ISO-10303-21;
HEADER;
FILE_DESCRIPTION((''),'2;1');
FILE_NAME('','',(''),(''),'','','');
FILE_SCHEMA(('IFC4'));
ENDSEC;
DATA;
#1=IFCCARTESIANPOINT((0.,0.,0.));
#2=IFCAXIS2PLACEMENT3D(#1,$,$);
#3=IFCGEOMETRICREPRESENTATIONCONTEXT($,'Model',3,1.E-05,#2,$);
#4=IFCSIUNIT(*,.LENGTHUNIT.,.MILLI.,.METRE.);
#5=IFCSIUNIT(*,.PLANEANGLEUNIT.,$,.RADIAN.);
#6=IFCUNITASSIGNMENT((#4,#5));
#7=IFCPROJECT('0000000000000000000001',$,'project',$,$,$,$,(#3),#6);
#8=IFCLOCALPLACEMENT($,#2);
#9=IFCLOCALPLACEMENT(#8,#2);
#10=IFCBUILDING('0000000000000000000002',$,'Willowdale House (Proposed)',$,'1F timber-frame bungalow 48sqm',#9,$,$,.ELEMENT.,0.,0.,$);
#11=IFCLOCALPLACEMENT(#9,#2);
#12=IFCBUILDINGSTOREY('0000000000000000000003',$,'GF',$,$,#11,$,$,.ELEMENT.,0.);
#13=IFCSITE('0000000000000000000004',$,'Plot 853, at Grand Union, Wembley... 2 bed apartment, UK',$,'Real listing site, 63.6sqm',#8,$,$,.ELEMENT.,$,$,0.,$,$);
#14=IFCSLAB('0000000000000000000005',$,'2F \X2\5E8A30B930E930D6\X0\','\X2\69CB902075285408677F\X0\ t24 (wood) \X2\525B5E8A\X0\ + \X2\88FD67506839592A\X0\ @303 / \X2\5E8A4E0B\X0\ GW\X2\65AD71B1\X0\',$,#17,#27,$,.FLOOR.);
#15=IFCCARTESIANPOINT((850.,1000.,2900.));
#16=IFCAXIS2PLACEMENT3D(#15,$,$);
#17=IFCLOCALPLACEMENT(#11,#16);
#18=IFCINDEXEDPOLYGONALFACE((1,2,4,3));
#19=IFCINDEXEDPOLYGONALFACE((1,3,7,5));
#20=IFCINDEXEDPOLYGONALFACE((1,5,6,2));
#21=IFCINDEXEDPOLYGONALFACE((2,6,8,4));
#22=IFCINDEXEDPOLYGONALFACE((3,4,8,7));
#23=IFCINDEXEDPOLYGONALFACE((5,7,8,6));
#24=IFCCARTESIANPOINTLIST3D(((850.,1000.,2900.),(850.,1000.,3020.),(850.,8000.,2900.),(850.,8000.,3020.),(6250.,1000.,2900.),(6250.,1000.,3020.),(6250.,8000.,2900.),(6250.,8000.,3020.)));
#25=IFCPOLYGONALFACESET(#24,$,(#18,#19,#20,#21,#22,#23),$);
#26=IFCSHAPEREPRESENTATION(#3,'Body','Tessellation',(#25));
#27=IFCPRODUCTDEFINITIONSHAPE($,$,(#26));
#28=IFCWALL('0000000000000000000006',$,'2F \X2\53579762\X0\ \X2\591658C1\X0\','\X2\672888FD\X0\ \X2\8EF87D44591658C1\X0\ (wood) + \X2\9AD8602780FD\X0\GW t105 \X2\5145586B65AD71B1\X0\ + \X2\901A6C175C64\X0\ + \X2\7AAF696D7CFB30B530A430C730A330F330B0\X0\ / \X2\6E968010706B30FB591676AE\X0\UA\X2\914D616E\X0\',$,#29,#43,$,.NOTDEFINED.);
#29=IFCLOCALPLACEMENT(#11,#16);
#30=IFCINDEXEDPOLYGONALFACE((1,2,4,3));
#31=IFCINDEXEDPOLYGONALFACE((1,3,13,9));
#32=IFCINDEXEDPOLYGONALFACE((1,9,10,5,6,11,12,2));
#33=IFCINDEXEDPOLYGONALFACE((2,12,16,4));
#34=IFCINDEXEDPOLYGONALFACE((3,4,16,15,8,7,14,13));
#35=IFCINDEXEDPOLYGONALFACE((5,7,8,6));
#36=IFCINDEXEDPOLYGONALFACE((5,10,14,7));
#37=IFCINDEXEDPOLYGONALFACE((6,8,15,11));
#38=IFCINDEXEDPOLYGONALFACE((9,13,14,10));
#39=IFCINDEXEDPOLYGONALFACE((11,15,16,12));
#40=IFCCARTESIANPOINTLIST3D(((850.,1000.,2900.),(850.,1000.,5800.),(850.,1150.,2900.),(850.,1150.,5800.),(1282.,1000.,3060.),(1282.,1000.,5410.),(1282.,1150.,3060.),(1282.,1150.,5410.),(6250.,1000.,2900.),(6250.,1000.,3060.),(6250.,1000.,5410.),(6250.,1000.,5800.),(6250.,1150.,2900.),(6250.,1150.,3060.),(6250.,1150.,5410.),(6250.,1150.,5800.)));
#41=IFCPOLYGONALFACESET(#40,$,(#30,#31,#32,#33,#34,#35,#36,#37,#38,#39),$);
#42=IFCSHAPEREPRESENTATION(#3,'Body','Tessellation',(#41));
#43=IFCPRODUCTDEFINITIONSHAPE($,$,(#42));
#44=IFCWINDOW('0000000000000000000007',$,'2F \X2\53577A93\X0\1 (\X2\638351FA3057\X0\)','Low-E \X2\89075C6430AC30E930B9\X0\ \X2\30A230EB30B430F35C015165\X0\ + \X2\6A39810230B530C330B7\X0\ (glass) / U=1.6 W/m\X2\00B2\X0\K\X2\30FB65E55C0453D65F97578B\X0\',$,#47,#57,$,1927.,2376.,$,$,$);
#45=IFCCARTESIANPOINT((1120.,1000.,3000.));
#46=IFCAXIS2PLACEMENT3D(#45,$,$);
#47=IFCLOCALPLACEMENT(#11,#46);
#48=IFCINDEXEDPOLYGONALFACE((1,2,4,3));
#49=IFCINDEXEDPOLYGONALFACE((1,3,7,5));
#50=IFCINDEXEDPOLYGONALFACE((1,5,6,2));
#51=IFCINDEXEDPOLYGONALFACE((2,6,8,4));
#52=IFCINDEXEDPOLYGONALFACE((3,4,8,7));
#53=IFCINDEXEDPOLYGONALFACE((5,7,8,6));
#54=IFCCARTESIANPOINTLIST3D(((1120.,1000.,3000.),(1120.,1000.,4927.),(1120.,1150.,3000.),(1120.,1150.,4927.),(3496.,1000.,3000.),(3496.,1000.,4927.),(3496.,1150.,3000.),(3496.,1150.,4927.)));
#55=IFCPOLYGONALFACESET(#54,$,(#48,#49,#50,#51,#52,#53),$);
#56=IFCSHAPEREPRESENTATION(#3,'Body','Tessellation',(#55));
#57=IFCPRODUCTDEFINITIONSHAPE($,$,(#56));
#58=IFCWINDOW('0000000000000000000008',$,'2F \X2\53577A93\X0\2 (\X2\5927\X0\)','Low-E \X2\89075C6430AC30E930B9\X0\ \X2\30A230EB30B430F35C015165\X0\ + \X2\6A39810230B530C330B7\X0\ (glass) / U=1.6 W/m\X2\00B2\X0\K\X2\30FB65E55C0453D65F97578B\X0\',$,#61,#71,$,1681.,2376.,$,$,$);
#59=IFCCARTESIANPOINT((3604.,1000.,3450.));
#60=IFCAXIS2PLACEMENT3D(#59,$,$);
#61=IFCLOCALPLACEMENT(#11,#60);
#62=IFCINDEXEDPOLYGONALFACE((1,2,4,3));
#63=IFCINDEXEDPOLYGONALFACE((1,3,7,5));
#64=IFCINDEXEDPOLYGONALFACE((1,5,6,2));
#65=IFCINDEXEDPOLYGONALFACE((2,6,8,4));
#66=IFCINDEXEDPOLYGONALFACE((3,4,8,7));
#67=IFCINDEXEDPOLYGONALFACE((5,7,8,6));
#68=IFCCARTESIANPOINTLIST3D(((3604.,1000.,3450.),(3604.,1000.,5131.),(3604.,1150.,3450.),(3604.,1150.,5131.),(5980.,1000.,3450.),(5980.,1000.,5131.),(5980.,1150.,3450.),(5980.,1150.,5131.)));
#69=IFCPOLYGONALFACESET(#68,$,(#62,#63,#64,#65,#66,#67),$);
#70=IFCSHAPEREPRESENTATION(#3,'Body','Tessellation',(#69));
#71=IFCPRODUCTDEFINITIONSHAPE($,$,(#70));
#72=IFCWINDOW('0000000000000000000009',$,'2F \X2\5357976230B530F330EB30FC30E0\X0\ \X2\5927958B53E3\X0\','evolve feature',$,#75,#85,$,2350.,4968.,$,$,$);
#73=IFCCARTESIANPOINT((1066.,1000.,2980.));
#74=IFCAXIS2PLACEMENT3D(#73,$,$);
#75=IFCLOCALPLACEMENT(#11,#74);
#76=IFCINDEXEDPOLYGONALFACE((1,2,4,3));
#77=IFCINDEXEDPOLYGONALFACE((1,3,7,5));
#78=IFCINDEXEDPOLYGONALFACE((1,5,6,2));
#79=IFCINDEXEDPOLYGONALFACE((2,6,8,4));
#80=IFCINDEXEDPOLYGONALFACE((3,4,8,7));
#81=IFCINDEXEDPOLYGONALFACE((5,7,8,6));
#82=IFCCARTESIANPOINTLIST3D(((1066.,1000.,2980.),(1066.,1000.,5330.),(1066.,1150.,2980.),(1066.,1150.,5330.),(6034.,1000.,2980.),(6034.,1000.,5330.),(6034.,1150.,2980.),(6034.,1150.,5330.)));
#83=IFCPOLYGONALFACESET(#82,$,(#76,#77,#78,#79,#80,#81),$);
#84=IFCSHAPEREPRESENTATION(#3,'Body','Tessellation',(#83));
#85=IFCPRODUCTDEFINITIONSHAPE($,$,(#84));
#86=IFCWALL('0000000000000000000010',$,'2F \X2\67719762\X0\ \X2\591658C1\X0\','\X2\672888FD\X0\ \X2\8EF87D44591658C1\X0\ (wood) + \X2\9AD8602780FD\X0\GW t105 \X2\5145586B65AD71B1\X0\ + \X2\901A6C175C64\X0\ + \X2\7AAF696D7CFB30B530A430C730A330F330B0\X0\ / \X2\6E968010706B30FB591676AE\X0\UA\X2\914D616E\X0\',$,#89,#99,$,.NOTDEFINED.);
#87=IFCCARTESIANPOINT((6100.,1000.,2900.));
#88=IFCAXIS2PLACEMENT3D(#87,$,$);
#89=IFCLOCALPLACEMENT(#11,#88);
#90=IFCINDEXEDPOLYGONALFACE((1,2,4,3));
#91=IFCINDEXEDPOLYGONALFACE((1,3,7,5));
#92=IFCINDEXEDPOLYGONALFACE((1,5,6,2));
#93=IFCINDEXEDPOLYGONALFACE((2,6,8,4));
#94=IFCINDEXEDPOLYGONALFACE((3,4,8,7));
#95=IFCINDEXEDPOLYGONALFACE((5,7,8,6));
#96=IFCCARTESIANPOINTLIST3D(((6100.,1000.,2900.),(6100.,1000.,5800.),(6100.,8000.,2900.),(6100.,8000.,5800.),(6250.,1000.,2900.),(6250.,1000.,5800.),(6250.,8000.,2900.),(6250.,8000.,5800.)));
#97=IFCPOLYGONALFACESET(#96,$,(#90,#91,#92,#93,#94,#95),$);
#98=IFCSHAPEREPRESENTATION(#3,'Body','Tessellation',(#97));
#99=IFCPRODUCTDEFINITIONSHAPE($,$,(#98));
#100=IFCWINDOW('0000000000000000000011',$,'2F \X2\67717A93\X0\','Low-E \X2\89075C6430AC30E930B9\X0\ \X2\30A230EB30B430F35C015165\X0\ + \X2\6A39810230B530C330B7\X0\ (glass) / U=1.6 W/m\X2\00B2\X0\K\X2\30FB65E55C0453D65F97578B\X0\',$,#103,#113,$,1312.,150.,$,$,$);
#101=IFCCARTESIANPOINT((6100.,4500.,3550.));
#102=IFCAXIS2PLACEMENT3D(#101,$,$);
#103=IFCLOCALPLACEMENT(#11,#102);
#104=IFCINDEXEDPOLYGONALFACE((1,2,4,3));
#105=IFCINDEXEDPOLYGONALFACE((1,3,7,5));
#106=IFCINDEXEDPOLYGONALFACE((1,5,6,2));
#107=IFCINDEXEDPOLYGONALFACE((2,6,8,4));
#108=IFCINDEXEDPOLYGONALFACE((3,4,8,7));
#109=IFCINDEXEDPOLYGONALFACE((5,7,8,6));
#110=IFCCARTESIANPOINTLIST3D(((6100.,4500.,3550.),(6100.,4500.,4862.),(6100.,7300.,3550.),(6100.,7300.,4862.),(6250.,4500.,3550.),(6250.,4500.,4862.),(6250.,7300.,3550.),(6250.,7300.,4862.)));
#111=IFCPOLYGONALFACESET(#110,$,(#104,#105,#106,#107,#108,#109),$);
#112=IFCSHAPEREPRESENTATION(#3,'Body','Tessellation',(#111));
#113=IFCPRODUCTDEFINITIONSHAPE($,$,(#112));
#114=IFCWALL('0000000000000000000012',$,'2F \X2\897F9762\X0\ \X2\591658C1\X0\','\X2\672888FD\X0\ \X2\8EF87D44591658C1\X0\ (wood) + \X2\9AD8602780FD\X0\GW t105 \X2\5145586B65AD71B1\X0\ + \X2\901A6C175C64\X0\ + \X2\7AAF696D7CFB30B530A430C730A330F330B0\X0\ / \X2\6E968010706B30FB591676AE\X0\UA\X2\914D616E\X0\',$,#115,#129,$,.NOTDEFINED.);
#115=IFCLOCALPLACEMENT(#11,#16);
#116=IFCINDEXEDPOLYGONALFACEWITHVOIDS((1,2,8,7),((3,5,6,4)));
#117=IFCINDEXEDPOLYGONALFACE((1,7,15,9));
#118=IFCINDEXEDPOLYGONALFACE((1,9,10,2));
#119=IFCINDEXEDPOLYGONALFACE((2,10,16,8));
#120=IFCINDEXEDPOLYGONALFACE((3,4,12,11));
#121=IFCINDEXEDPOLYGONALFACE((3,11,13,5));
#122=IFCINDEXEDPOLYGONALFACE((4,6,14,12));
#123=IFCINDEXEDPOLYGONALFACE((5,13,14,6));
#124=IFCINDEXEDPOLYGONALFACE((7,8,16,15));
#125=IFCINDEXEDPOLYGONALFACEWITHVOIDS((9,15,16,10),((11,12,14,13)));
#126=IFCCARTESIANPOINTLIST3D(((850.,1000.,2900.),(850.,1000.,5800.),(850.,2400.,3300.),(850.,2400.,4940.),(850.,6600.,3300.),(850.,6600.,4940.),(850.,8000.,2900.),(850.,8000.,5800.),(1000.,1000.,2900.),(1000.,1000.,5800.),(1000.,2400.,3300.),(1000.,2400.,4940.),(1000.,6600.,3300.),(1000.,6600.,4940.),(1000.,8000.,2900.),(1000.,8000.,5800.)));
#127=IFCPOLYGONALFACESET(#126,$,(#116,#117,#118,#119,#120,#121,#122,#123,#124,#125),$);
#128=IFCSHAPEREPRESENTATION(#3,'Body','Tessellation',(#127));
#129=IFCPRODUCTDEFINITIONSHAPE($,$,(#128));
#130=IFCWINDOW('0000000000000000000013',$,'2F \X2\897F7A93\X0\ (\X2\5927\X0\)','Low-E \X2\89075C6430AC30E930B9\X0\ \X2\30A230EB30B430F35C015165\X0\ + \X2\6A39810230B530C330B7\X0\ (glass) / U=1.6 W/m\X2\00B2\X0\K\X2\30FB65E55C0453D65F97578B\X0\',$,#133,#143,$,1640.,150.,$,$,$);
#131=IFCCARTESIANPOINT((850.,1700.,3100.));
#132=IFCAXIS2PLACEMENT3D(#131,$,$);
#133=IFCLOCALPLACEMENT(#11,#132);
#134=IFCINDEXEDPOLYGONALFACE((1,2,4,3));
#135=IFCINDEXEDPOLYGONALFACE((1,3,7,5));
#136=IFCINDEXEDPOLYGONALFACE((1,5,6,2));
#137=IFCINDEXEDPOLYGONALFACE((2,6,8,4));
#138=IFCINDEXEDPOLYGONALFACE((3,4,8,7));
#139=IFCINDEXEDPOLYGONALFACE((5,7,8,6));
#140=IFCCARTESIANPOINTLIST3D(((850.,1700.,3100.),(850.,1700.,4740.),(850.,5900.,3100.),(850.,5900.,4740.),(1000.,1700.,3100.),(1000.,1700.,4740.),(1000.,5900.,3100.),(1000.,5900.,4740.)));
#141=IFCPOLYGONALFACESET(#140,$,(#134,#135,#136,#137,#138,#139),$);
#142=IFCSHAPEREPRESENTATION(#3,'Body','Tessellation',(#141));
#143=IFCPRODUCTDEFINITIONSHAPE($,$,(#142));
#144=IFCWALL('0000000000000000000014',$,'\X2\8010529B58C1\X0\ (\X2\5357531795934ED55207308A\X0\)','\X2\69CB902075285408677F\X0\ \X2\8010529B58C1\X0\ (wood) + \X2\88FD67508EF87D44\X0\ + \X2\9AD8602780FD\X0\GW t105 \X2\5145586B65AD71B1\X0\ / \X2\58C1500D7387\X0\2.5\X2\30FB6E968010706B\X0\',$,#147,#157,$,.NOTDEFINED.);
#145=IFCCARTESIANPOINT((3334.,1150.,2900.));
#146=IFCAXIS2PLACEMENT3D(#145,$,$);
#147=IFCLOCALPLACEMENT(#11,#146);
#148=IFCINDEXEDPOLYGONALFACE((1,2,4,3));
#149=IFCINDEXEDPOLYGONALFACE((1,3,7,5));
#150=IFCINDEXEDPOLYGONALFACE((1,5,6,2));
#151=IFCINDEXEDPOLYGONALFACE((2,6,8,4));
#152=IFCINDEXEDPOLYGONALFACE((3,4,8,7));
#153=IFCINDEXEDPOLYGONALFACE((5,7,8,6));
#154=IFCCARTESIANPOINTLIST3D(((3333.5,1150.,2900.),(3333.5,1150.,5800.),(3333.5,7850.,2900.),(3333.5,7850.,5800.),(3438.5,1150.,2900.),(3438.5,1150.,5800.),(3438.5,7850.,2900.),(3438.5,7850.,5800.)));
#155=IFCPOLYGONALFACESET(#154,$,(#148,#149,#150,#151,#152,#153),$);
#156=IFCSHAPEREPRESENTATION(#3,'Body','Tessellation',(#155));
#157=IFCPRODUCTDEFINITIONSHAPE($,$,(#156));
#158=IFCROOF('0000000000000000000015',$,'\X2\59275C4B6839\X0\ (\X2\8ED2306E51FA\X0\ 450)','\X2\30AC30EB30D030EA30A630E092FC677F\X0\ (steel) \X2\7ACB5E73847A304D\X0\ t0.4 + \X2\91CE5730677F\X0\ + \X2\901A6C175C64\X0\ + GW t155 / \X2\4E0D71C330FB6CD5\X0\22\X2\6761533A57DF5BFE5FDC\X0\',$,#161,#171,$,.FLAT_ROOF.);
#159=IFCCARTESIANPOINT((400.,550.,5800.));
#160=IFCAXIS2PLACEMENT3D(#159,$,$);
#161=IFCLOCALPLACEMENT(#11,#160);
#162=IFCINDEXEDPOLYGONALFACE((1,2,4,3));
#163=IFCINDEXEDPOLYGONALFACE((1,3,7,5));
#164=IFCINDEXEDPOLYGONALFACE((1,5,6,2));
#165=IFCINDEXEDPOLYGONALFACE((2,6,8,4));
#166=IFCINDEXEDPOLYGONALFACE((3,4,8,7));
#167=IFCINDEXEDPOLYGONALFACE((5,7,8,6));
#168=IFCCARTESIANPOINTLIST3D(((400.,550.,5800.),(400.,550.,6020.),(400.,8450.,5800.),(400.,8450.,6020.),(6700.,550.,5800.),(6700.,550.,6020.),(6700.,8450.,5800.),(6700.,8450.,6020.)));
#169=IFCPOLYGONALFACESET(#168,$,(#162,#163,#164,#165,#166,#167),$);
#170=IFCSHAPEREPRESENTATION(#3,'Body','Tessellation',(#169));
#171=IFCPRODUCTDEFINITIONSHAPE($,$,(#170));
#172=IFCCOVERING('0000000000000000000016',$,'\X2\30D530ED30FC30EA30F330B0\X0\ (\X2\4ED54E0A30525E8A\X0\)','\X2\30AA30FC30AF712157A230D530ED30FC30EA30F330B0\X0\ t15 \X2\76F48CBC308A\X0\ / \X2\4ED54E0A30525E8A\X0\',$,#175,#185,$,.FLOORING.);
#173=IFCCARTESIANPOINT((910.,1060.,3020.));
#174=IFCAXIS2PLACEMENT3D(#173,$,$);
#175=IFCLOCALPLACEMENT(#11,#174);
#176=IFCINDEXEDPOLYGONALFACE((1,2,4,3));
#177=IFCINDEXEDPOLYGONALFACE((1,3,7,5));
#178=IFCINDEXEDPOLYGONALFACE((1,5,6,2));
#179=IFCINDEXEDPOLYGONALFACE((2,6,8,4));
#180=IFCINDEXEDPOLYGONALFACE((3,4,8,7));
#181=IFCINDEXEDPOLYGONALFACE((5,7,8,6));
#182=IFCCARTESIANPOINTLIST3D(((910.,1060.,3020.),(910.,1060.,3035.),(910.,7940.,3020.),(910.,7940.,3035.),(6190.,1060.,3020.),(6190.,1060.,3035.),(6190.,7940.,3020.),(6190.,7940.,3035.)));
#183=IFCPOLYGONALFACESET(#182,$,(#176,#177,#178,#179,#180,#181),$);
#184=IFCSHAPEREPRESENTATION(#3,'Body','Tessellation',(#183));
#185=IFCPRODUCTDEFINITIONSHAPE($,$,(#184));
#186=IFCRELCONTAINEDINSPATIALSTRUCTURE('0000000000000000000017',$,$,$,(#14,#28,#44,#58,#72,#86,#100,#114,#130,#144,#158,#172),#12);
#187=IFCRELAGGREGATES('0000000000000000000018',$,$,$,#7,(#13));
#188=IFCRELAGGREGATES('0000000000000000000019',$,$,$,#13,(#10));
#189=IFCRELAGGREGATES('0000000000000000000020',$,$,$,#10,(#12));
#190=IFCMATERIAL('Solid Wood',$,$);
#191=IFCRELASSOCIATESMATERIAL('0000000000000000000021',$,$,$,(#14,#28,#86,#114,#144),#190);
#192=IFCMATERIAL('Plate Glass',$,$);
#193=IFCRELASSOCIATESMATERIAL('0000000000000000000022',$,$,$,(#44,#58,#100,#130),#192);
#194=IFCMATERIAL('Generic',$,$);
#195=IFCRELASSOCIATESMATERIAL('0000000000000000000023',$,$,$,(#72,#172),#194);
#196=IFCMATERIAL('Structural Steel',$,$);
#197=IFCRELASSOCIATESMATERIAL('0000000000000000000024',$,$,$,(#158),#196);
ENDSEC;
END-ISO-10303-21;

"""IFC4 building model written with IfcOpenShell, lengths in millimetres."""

from ifc_helpers import new_model, si_unit, frame, frame_2d, origin, place, context, project, spatial, rectangle, extrude, material, element, fill, save


model = new_model("IFC4")

# Units and contexts
model_context = context("Model", 3, precision=1e-05, world=origin())
ifc_project = project(units=[si_unit("LENGTHUNIT", "METRE", prefix="MILLI"), si_unit("PLANEANGLEUNIT", "RADIAN")], contexts=[model_context])

# Site, building, storey
site_placement = place(None, origin())
site = spatial("IfcSite", under=ifc_project, at=site_placement, Name="Plot 853, at Grand Union, Wembley... 2 bed apartment, UK", ObjectType="Real listing site, 63.6sqm", CompositionType="ELEMENT", RefElevation=0.0)
building_placement = place(site_placement, origin())
building = spatial("IfcBuilding", under=site, at=building_placement, Name="Willowdale House (Proposed)", ObjectType="1F timber-frame bungalow 48sqm", CompositionType="ELEMENT", ElevationOfRefHeight=0.0, ElevationOfTerrain=0.0)
storey_placement = place(building_placement, origin())
storey = spatial("IfcBuildingStorey", under=building, at=storey_placement, Name="GF", CompositionType="ELEMENT", Elevation=0.0)

# Slab
ifc_material_1 = material(Name="Solid Wood")
slab_placement = place(storey_placement, frame((850.0, 1000.0, 2900.0)))
element("IfcSlab", 1, at=slab_placement, inside=storey, material=ifc_material_1, Name="2F 床スラブ", Description="構造用合板 t24 (wood) 剛床 + 製材根太 @303 / 床下 GW断熱", PredefinedType="FLOOR", context=model_context, shape_type="SweptSolid", body=[
    extrude(rectangle(XDim=5400.0, YDim=7000.0, at=frame_2d((2700.0, 3500.0))), frame((850.0, 1000.0, 2900.0)), (0.0, 0.0, 1.0), 120.0),
])

# Wall, openings, windows
wall_1_placement = place(storey_placement, frame((850.0, 1000.0, 2900.0)))
wall_1 = element("IfcWall", 2, at=wall_1_placement, inside=storey, material=ifc_material_1, Name="2F 南面 外壁", Description="木製 軸組外壁 (wood) + 高性能GW t105 充填断熱 + 通気層 + 窯業系サイディング / 準耐火・外皮UA配慮", PredefinedType="NOTDEFINED", context=model_context, shape_type="SweptSolid", body=[
    extrude(rectangle(XDim=5400.0, YDim=150.0, at=frame_2d((2700.0, 75.0))), frame((850.0, 1000.0, 2900.0)), (0.0, 0.0, 1.0), 2900.0),
])
opening_1_placement = place(storey_placement, frame((1120.0, 1000.0, 3000.0)))
opening_1 = element("IfcOpeningElement", 3, at=opening_1_placement, cuts=wall_1, PredefinedType="NOTDEFINED", context=model_context, shape_type="SweptSolid", body=[
    extrude(rectangle(XDim=2376.0, YDim=150.0, at=frame_2d((1188.0, 75.0))), frame((1120.0, 1000.0, 3000.0)), (0.0, 0.0, 1.0), 1927.0),
])
opening_2_placement = place(storey_placement, frame((3604.0, 1000.0, 3450.0)))
opening_2 = element("IfcOpeningElement", 4, at=opening_2_placement, cuts=wall_1, PredefinedType="NOTDEFINED", context=model_context, shape_type="SweptSolid", body=[
    extrude(rectangle(XDim=2376.0, YDim=150.0, at=frame_2d((1188.0, 75.0))), frame((3604.0, 1000.0, 3450.0)), (0.0, 0.0, 1.0), 1681.0),
])
opening_3_placement = place(storey_placement, frame((1066.0, 1000.0, 2980.0)))
opening_3 = element("IfcOpeningElement", 5, at=opening_3_placement, cuts=wall_1, PredefinedType="NOTDEFINED", context=model_context, shape_type="SweptSolid", body=[
    extrude(rectangle(XDim=4968.0, YDim=150.0, at=frame_2d((2484.0, 75.0))), frame((1066.0, 1000.0, 2980.0)), (0.0, 0.0, 1.0), 2350.0),
])
ifc_material_2 = material(Name="Plate Glass")
window_1_placement = place(storey_placement, frame((1120.0, 1000.0, 3000.0)))
window_1 = element("IfcWindow", 6, at=window_1_placement, inside=storey, material=ifc_material_2, Name="2F 南窓1 (掃出し)", Description="Low-E 複層ガラス アルゴン封入 + 樹脂サッシ (glass) / U=1.6 W/m²K・日射取得型", OverallHeight=1927.0, OverallWidth=2376.0, context=model_context, shape_type="SweptSolid", body=[
    extrude(rectangle(XDim=2376.0, YDim=150.0, at=frame_2d((1188.0, 75.0))), frame((1120.0, 1000.0, 3000.0)), (0.0, 0.0, 1.0), 1927.0),
])
fill(opening_1, window_1)
window_2_placement = place(storey_placement, frame((3604.0, 1000.0, 3450.0)))
window_2 = element("IfcWindow", 7, at=window_2_placement, inside=storey, material=ifc_material_2, Name="2F 南窓2 (大)", Description="Low-E 複層ガラス アルゴン封入 + 樹脂サッシ (glass) / U=1.6 W/m²K・日射取得型", OverallHeight=1681.0, OverallWidth=2376.0, context=model_context, shape_type="SweptSolid", body=[
    extrude(rectangle(XDim=2376.0, YDim=150.0, at=frame_2d((1188.0, 75.0))), frame((3604.0, 1000.0, 3450.0)), (0.0, 0.0, 1.0), 1681.0),
])
fill(opening_2, window_2)
ifc_material_3 = material(Name="Generic")
window_3_placement = place(storey_placement, frame((1066.0, 1000.0, 2980.0)))
window_3 = element("IfcWindow", 8, at=window_3_placement, inside=storey, material=ifc_material_3, Name="2F 南面サンルーム 大開口", Description="evolve feature", OverallHeight=2350.0, OverallWidth=4968.0, context=model_context, shape_type="SweptSolid", body=[
    extrude(rectangle(XDim=4968.0, YDim=150.0, at=frame_2d((2484.0, 75.0))), frame((1066.0, 1000.0, 2980.0)), (0.0, 0.0, 1.0), 2350.0),
])
fill(opening_3, window_3)

# Walls, openings, windows
wall_2_placement = place(storey_placement, frame((6100.0, 1000.0, 2900.0)))
wall_2 = element("IfcWall", 9, at=wall_2_placement, inside=storey, material=ifc_material_1, Name="2F 東面 外壁", Description="木製 軸組外壁 (wood) + 高性能GW t105 充填断熱 + 通気層 + 窯業系サイディング / 準耐火・外皮UA配慮", PredefinedType="NOTDEFINED", context=model_context, shape_type="SweptSolid", body=[
    extrude(rectangle(XDim=150.0, YDim=7000.0, at=frame_2d((75.0, 3500.0))), frame((6100.0, 1000.0, 2900.0)), (0.0, 0.0, 1.0), 2900.0),
])
opening_4_placement = place(storey_placement, frame((6100.0, 4500.0, 3550.0)))
opening_4 = element("IfcOpeningElement", 10, at=opening_4_placement, cuts=wall_2, PredefinedType="NOTDEFINED", context=model_context, shape_type="SweptSolid", body=[
    extrude(rectangle(XDim=150.0, YDim=2800.0, at=frame_2d((75.0, 1400.0))), frame((6100.0, 4500.0, 3550.0)), (0.0, 0.0, 1.0), 1312.0),
])
window_4_placement = place(storey_placement, frame((6100.0, 4500.0, 3550.0)))
window_4 = element("IfcWindow", 11, at=window_4_placement, inside=storey, material=ifc_material_2, Name="2F 東窓", Description="Low-E 複層ガラス アルゴン封入 + 樹脂サッシ (glass) / U=1.6 W/m²K・日射取得型", OverallHeight=1312.0, OverallWidth=150.0, context=model_context, shape_type="SweptSolid", body=[
    extrude(rectangle(XDim=150.0, YDim=2800.0, at=frame_2d((75.0, 1400.0))), frame((6100.0, 4500.0, 3550.0)), (0.0, 0.0, 1.0), 1312.0),
])
fill(opening_4, window_4)
wall_3_placement = place(storey_placement, frame((850.0, 1000.0, 2900.0)))
wall_3 = element("IfcWall", 12, at=wall_3_placement, inside=storey, material=ifc_material_1, Name="2F 西面 外壁", Description="木製 軸組外壁 (wood) + 高性能GW t105 充填断熱 + 通気層 + 窯業系サイディング / 準耐火・外皮UA配慮", PredefinedType="NOTDEFINED", context=model_context, shape_type="SweptSolid", body=[
    extrude(rectangle(XDim=150.0, YDim=7000.0, at=frame_2d((75.0, 3500.0))), frame((850.0, 1000.0, 2900.0)), (0.0, 0.0, 1.0), 2900.0),
])
opening_5_placement = place(storey_placement, frame((850.0, 1700.0, 3100.0)))
opening_5 = element("IfcOpeningElement", 13, at=opening_5_placement, cuts=wall_3, PredefinedType="NOTDEFINED", context=model_context, shape_type="SweptSolid", body=[
    extrude(rectangle(XDim=150.0, YDim=4200.0, at=frame_2d((75.0, 2100.0))), frame((850.0, 1700.0, 3100.0)), (0.0, 0.0, 1.0), 1640.0),
])
window_5_placement = place(storey_placement, frame((850.0, 1700.0, 3100.0)))
window_5 = element("IfcWindow", 14, at=window_5_placement, inside=storey, material=ifc_material_2, Name="2F 西窓 (大)", Description="Low-E 複層ガラス アルゴン封入 + 樹脂サッシ (glass) / U=1.6 W/m²K・日射取得型", OverallHeight=1640.0, OverallWidth=150.0, context=model_context, shape_type="SweptSolid", body=[
    extrude(rectangle(XDim=150.0, YDim=4200.0, at=frame_2d((75.0, 2100.0))), frame((850.0, 1700.0, 3100.0)), (0.0, 0.0, 1.0), 1640.0),
])
fill(opening_5, window_5)

# Wall
wall_4_placement = place(storey_placement, frame((3334.0, 1150.0, 2900.0)))
element("IfcWall", 15, at=wall_4_placement, inside=storey, material=ifc_material_1, Name="耐力壁 (南北間仕切り)", Description="構造用合板 耐力壁 (wood) + 製材軸組 + 高性能GW t105 充填断熱 / 壁倍率2.5・準耐火", PredefinedType="NOTDEFINED", context=model_context, shape_type="SweptSolid", body=[
    extrude(rectangle(XDim=105.0, YDim=6700.0, at=frame_2d((52.0, 3350.0))), frame((3334.0, 1150.0, 2900.0)), (0.0, 0.0, 1.0), 2900.0),
])

# Roof
ifc_material_4 = material(Name="Structural Steel")
roof_placement = place(storey_placement, frame((400.0, 550.0, 5800.0)))
element("IfcRoof", 16, at=roof_placement, inside=storey, material=ifc_material_4, Name="大屋根 (軒の出 450)", Description="ガルバリウム鋼板 (steel) 立平葺き t0.4 + 野地板 + 通気層 + GW t155 / 不燃・法22条区域対応", PredefinedType="FLAT_ROOF", context=model_context, shape_type="SweptSolid", body=[
    extrude(rectangle(XDim=6300.0, YDim=7900.0, at=frame_2d((3150.0, 3950.0))), frame((400.0, 550.0, 5800.0)), (0.0, 0.0, 1.0), 220.0),
])

# Covering
covering_placement = place(storey_placement, frame((910.0, 1060.0, 3020.0)))
element("IfcCovering", 17, at=covering_placement, inside=storey, material=ifc_material_3, Name="フローリング (仕上げ床)", Description="オーク無垢フローリング t15 直貼り / 仕上げ床", PredefinedType="FLOORING", context=model_context, shape_type="SweptSolid", body=[
    extrude(rectangle(XDim=5280.0, YDim=6880.0, at=frame_2d((2640.0, 3440.0))), frame((910.0, 1060.0, 3020.0)), (0.0, 0.0, 1.0), 15.0),
])

save(model, "model.ifc")
